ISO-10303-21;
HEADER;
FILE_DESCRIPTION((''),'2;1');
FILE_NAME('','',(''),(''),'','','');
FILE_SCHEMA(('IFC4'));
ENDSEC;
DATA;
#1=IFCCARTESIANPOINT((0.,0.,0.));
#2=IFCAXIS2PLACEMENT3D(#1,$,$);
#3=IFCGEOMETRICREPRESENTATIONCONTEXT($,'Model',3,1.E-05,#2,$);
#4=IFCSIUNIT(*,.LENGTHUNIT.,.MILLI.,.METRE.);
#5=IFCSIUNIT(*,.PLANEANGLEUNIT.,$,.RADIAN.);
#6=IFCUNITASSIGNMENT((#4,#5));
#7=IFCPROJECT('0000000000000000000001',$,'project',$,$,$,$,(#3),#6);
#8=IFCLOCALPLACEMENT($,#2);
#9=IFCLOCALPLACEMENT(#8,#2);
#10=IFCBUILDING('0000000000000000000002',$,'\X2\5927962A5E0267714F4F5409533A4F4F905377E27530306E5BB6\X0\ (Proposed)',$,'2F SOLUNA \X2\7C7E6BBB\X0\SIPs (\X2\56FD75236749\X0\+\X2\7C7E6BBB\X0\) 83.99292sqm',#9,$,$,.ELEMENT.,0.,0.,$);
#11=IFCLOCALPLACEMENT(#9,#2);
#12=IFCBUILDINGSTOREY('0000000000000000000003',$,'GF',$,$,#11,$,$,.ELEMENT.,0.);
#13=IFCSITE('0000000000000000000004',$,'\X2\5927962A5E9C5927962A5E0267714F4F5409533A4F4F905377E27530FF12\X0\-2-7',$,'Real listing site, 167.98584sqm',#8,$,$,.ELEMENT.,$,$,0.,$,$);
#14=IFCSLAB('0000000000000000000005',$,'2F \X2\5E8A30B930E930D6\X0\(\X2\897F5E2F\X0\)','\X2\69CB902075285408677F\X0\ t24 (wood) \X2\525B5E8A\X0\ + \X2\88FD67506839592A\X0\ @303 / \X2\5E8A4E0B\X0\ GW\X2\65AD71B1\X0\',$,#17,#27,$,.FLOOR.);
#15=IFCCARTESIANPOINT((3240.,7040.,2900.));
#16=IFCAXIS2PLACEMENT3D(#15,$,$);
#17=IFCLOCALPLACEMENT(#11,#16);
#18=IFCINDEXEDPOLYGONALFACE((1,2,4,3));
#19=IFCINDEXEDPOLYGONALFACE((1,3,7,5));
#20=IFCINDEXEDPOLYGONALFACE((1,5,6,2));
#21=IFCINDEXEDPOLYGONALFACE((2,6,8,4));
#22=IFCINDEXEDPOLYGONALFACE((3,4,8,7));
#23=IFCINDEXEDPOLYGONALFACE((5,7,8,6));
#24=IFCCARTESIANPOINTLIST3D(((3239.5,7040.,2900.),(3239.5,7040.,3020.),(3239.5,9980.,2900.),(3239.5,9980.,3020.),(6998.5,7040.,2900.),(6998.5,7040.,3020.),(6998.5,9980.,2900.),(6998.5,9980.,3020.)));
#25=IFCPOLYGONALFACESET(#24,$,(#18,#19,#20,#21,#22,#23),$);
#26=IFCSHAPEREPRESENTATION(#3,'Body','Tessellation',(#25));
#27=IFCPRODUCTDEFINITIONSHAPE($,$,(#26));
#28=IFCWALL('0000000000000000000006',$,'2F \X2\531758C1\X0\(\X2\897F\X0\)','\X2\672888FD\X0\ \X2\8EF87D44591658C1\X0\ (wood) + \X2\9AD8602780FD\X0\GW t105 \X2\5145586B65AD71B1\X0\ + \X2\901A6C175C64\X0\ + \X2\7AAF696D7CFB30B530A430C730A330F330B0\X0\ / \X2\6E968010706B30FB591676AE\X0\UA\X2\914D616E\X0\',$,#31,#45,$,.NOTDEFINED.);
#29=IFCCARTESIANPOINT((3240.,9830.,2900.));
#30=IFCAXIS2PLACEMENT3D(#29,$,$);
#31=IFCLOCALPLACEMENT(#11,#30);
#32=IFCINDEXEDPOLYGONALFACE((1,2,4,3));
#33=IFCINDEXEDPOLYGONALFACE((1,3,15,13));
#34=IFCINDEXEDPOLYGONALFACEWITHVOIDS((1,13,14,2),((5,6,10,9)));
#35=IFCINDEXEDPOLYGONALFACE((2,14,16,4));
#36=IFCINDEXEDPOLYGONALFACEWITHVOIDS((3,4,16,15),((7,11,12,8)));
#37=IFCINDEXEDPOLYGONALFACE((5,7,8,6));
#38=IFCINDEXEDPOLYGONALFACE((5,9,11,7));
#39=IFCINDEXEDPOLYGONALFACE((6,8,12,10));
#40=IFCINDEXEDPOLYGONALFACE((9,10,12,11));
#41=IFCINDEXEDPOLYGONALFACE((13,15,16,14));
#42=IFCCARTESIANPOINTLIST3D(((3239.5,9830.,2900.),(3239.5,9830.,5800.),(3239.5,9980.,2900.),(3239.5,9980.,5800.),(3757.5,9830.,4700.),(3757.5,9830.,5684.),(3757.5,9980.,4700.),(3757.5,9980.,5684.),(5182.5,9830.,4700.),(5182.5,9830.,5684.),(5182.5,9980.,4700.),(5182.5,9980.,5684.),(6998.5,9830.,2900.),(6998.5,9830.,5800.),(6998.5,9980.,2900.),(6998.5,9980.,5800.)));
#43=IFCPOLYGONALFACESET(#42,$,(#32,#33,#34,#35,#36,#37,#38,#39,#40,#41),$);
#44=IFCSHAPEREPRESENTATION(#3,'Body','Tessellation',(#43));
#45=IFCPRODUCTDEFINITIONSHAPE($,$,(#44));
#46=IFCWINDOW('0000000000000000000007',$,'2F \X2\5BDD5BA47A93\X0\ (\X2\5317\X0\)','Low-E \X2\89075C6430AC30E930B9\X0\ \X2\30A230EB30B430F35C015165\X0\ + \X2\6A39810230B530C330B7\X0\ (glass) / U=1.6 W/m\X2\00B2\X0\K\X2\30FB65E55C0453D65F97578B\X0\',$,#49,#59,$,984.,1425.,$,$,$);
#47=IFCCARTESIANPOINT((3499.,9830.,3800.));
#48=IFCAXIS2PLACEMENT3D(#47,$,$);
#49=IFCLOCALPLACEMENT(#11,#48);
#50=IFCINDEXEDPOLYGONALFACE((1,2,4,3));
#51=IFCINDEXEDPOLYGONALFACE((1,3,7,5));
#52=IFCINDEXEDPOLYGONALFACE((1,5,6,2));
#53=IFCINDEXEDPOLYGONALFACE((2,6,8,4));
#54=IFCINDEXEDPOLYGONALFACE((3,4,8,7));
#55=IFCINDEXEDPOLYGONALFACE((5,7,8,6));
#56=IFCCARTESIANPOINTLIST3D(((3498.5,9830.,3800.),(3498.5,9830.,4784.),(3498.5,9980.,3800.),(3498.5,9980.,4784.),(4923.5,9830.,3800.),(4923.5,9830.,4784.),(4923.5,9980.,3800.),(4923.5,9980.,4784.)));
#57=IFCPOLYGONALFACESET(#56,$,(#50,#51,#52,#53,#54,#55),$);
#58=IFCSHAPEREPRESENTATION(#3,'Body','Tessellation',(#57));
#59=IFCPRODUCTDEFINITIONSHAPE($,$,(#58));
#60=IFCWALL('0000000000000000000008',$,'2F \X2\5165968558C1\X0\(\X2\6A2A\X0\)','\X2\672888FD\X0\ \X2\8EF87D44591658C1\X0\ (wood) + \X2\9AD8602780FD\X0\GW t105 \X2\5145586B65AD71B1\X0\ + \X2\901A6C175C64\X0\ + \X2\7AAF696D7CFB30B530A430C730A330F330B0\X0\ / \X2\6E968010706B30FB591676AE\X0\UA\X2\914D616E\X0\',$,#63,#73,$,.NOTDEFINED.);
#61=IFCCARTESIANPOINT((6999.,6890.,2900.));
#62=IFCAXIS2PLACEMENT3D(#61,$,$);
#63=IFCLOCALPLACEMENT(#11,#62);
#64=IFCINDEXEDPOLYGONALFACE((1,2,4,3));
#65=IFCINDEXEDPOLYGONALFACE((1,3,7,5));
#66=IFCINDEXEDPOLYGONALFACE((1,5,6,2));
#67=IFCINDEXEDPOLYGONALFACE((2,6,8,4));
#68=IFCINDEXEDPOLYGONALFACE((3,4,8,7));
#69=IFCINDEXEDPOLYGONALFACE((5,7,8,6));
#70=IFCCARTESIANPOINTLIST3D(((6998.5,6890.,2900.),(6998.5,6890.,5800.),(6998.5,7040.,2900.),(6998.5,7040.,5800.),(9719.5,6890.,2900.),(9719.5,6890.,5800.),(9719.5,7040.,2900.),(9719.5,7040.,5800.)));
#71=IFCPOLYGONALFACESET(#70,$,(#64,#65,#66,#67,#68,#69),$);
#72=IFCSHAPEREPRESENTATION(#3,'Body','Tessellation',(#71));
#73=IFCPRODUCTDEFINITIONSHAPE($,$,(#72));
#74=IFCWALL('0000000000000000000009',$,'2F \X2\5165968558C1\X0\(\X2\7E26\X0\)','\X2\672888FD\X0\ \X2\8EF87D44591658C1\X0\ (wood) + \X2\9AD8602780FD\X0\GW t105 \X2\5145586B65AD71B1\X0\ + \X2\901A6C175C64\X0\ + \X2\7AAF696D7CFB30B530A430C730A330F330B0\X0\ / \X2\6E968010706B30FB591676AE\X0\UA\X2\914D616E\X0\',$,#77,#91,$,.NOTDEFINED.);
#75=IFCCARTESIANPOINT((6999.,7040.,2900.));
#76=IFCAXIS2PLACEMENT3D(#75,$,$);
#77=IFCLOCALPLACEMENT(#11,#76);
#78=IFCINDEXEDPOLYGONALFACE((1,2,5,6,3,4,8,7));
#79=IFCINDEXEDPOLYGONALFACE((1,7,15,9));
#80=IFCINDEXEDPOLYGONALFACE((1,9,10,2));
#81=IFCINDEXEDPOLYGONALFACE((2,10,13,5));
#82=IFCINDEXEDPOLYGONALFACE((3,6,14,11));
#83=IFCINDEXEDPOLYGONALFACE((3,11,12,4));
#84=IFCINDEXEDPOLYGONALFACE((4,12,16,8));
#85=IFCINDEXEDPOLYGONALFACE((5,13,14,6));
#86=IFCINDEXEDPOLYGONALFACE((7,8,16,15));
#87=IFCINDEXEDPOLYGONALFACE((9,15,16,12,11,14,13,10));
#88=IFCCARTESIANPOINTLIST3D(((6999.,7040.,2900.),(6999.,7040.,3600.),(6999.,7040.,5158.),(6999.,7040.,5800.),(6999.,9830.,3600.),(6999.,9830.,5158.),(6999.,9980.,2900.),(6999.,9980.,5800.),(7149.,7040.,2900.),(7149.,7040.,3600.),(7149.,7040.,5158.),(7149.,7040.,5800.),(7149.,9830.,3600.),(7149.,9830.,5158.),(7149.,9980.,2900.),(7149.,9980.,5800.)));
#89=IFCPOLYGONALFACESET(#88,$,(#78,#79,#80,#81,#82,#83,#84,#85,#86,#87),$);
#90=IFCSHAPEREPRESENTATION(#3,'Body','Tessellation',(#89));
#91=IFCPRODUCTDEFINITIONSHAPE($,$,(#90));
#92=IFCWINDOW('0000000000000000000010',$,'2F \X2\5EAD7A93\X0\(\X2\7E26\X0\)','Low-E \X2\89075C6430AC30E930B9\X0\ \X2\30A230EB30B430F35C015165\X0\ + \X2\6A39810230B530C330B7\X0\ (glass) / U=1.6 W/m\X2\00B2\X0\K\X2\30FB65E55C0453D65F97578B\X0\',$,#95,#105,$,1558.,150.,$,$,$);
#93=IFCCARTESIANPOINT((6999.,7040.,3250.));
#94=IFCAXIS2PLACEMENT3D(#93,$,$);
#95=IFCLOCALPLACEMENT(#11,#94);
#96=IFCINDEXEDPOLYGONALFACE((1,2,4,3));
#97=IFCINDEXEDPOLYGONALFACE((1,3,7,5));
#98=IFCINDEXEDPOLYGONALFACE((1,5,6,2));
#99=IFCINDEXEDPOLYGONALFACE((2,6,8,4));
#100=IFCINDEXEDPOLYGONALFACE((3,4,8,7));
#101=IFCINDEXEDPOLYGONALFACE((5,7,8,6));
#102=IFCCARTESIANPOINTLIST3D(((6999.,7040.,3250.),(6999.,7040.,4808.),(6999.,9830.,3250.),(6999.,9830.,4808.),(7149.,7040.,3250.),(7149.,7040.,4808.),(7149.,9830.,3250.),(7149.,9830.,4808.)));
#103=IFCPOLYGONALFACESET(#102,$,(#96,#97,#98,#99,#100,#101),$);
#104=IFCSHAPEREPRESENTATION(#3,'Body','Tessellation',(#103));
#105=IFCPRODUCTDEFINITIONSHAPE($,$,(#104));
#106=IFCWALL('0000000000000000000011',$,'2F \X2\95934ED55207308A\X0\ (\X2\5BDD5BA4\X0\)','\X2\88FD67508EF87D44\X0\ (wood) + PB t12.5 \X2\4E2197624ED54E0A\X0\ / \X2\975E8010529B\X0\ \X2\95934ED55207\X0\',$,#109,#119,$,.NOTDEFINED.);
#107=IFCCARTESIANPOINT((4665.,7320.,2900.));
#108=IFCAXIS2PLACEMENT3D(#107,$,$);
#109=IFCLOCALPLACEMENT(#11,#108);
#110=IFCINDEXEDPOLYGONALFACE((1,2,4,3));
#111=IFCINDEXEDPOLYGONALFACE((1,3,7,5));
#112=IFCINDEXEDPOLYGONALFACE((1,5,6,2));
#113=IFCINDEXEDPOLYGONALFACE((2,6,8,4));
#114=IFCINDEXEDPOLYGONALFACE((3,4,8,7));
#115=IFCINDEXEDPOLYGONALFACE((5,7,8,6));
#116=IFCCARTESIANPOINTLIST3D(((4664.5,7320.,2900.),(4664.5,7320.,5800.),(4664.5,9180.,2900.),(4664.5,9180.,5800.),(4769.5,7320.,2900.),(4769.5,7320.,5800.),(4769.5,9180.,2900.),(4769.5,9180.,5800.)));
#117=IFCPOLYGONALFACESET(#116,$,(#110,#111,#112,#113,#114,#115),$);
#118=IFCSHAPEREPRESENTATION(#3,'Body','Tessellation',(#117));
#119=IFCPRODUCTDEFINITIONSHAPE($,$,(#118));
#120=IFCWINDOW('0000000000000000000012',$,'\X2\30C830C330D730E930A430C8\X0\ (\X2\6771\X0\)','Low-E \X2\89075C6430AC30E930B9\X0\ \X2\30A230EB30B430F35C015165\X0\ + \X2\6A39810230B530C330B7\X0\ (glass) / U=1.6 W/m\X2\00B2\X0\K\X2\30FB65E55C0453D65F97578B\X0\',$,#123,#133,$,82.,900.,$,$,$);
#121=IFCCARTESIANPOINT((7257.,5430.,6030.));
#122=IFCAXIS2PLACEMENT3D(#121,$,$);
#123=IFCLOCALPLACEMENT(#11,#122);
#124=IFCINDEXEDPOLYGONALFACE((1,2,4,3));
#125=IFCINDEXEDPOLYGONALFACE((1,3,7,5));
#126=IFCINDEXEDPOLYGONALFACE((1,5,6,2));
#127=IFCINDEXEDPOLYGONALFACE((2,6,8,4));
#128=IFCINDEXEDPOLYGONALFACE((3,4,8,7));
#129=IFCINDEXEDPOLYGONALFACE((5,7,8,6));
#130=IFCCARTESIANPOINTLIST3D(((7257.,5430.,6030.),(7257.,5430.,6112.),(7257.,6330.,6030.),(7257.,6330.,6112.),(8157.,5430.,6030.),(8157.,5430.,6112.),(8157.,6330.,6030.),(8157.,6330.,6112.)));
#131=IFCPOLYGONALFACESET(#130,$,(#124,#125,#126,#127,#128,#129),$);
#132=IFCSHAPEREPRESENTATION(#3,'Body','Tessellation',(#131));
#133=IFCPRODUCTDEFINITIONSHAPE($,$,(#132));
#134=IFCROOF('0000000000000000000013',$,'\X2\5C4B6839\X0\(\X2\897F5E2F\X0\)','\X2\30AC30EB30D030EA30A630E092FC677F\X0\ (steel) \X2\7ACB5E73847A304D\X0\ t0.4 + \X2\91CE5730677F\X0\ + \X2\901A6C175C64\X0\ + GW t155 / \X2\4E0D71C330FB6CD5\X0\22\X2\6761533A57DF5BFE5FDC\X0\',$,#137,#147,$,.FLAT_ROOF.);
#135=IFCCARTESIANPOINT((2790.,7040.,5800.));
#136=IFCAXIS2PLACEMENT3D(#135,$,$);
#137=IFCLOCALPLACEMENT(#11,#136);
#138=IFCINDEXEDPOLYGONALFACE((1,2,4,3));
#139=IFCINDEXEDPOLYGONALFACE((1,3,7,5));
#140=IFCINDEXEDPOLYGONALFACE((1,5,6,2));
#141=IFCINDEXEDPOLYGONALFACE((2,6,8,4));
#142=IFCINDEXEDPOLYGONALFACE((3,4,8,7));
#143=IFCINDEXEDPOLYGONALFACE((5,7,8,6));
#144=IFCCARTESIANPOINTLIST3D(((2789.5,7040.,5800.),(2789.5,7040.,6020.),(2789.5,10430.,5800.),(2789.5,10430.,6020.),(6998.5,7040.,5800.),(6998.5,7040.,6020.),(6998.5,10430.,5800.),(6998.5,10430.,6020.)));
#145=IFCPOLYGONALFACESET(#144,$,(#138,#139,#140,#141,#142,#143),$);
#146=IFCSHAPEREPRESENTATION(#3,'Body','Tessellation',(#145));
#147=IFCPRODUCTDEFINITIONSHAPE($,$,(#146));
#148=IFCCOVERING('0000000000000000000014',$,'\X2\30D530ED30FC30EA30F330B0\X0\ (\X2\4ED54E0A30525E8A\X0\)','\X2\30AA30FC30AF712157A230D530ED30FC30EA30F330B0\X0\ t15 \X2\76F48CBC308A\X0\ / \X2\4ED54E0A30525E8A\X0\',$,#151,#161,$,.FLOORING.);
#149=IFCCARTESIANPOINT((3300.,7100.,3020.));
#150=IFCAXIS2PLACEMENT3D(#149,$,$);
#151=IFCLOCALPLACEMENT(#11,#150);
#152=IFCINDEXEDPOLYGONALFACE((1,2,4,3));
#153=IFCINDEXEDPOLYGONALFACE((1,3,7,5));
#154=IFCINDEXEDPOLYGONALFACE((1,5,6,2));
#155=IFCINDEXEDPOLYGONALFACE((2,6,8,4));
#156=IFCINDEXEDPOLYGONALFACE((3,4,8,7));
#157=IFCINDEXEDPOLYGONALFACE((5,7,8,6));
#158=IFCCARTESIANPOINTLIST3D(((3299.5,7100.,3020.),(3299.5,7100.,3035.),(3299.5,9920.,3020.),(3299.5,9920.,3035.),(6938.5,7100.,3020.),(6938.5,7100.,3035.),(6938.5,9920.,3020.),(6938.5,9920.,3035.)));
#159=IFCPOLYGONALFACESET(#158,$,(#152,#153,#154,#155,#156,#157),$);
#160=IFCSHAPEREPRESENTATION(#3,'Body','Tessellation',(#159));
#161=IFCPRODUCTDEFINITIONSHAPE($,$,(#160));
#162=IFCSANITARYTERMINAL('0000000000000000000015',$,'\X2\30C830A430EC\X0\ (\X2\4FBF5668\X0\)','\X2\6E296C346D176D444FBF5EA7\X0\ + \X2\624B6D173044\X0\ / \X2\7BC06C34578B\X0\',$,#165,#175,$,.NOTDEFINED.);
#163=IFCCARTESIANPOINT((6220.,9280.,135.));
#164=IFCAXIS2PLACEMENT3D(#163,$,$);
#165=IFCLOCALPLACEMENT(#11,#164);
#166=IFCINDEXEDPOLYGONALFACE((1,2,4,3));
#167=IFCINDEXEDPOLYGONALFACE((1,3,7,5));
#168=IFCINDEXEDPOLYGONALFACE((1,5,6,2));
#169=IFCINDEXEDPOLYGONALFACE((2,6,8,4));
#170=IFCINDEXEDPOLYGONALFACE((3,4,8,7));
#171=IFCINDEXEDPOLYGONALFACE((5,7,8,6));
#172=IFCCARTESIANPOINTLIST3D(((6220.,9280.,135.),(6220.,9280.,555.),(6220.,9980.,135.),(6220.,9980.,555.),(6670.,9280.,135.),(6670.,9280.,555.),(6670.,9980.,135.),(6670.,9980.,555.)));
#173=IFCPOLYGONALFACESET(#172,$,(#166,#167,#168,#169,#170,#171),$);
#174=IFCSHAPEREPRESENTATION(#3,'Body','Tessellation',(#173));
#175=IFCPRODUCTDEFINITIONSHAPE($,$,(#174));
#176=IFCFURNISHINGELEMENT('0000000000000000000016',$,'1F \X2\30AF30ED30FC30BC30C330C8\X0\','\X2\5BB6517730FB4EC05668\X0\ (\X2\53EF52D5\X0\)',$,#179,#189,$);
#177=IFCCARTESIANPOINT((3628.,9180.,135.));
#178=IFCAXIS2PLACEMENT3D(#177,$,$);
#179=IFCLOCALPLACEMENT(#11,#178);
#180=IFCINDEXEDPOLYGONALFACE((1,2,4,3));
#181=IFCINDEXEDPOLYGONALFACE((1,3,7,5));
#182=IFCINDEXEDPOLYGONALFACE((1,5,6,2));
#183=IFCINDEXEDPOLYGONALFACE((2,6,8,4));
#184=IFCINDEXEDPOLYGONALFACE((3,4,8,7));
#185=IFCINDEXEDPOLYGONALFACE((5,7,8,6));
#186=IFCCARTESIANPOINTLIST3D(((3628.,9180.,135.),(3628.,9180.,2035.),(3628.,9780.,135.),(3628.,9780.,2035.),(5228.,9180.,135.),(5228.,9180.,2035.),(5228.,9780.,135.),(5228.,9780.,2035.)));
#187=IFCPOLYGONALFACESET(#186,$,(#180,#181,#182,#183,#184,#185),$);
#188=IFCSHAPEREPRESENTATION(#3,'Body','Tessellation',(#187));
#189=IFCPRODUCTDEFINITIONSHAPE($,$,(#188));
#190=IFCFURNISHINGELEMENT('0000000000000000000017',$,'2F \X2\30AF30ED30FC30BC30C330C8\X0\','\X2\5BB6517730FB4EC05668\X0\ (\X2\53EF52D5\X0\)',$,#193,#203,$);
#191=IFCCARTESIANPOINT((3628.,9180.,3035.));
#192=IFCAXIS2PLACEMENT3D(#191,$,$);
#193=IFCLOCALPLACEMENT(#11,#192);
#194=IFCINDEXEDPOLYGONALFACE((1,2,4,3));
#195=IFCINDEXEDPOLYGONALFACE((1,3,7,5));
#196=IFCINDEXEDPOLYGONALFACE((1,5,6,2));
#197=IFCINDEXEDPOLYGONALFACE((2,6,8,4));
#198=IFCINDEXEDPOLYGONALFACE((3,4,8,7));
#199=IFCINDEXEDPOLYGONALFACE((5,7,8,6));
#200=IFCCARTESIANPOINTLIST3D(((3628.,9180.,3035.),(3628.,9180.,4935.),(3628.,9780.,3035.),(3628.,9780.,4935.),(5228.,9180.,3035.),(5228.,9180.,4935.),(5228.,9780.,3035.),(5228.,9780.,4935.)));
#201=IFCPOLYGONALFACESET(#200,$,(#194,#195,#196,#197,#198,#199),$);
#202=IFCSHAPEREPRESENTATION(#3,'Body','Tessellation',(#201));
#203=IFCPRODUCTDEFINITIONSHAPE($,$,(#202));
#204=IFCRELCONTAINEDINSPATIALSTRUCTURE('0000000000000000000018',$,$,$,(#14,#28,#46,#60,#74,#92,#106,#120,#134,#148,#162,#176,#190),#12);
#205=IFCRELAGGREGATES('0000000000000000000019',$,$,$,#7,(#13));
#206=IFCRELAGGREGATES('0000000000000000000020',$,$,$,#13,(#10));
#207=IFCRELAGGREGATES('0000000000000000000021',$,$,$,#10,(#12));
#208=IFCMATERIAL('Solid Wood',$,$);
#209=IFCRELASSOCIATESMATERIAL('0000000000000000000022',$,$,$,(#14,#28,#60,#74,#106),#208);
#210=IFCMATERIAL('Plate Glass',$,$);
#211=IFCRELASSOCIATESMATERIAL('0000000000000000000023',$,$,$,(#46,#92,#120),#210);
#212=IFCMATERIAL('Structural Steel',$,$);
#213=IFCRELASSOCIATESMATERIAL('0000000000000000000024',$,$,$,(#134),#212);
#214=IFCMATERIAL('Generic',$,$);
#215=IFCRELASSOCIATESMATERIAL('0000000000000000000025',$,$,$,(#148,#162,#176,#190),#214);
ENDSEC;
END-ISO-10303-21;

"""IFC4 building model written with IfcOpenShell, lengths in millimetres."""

from ifc_helpers import new_model, si_unit, frame, frame_2d, origin, place, context, project, spatial, rectangle, extrude, material, element, fill, save


model = new_model("IFC4")

# Units and contexts
model_context = context("Model", 3, precision=1e-05, world=origin())
ifc_project = project(units=[si_unit("LENGTHUNIT", "METRE", prefix="MILLI"), si_unit("PLANEANGLEUNIT", "RADIAN")], contexts=[model_context])

# Site, building, storey
site_placement = place(None, origin())
site = spatial("IfcSite", under=ifc_project, at=site_placement, Name="大阪府大阪市東住吉区住道矢田２-2-7", ObjectType="Real listing site, 167.98584sqm", CompositionType="ELEMENT", RefElevation=0.0)
building_placement = place(site_placement, origin())
building = spatial("IfcBuilding", under=site, at=building_placement, Name="大阪市東住吉区住道矢田の家 (Proposed)", ObjectType="2F SOLUNA 籾殻SIPs (国産杉+籾殻) 83.99292sqm", CompositionType="ELEMENT", ElevationOfRefHeight=0.0, ElevationOfTerrain=0.0)
storey_placement = place(building_placement, origin())
storey = spatial("IfcBuildingStorey", under=building, at=storey_placement, Name="GF", CompositionType="ELEMENT", Elevation=0.0)

# Slab
ifc_material_1 = material(Name="Solid Wood")
slab_placement = place(storey_placement, frame((3240.0, 7040.0, 2900.0)))
element("IfcSlab", 1, at=slab_placement, inside=storey, material=ifc_material_1, Name="2F 床スラブ(西帯)", Description="構造用合板 t24 (wood) 剛床 + 製材根太 @303 / 床下 GW断熱", PredefinedType="FLOOR", context=model_context, shape_type="SweptSolid", body=[
    extrude(rectangle(XDim=3759.0, YDim=2940.0, at=frame_2d((1879.0, 1470.0))), frame((3240.0, 7040.0, 2900.0)), (0.0, 0.0, 1.0), 120.0),
])

# Wall, opening, window
wall_1_placement = place(storey_placement, frame((3240.0, 9830.0, 2900.0)))
wall_1 = element("IfcWall", 2, at=wall_1_placement, inside=storey, material=ifc_material_1, Name="2F 北壁(西)", Description="木製 軸組外壁 (wood) + 高性能GW t105 充填断熱 + 通気層 + 窯業系サイディング / 準耐火・外皮UA配慮", PredefinedType="NOTDEFINED", context=model_context, shape_type="SweptSolid", body=[
    extrude(rectangle(XDim=3759.0, YDim=150.0, at=frame_2d((1879.0, 75.0))), frame((3240.0, 9830.0, 2900.0)), (0.0, 0.0, 1.0), 2900.0),
])
opening_1_placement = place(storey_placement, frame((3499.0, 9830.0, 3800.0)))
opening_1 = element("IfcOpeningElement", 3, at=opening_1_placement, cuts=wall_1, PredefinedType="NOTDEFINED", context=model_context, shape_type="SweptSolid", body=[
    extrude(rectangle(XDim=1425.0, YDim=150.0, at=frame_2d((712.0, 75.0))), frame((3499.0, 9830.0, 3800.0)), (0.0, 0.0, 1.0), 984.0),
])
ifc_material_2 = material(Name="Plate Glass")
window_1_placement = place(storey_placement, frame((3499.0, 9830.0, 3800.0)))
window_1 = element("IfcWindow", 4, at=window_1_placement, inside=storey, material=ifc_material_2, Name="2F 寝室窓 (北)", Description="Low-E 複層ガラス アルゴン封入 + 樹脂サッシ (glass) / U=1.6 W/m²K・日射取得型", OverallHeight=984.0, OverallWidth=1425.0, context=model_context, shape_type="SweptSolid", body=[
    extrude(rectangle(XDim=1425.0, YDim=150.0, at=frame_2d((712.0, 75.0))), frame((3499.0, 9830.0, 3800.0)), (0.0, 0.0, 1.0), 984.0),
])
fill(opening_1, window_1)

# Wall
wall_2_placement = place(storey_placement, frame((6999.0, 6890.0, 2900.0)))
element("IfcWall", 5, at=wall_2_placement, inside=storey, material=ifc_material_1, Name="2F 入隅壁(横)", Description="木製 軸組外壁 (wood) + 高性能GW t105 充填断熱 + 通気層 + 窯業系サイディング / 準耐火・外皮UA配慮", PredefinedType="NOTDEFINED", context=model_context, shape_type="SweptSolid", body=[
    extrude(rectangle(XDim=2721.0, YDim=150.0, at=frame_2d((1360.0, 75.0))), frame((6999.0, 6890.0, 2900.0)), (0.0, 0.0, 1.0), 2900.0),
])

# Wall, opening, window
wall_3_placement = place(storey_placement, frame((6999.0, 7040.0, 2900.0)))
wall_3 = element("IfcWall", 6, at=wall_3_placement, inside=storey, material=ifc_material_1, Name="2F 入隅壁(縦)", Description="木製 軸組外壁 (wood) + 高性能GW t105 充填断熱 + 通気層 + 窯業系サイディング / 準耐火・外皮UA配慮", PredefinedType="NOTDEFINED", context=model_context, shape_type="SweptSolid", body=[
    extrude(rectangle(XDim=150.0, YDim=2940.0, at=frame_2d((75.0, 1470.0))), frame((6999.0, 7040.0, 2900.0)), (0.0, 0.0, 1.0), 2900.0),
])
opening_2_placement = place(storey_placement, frame((6999.0, 7040.0, 3250.0)))
opening_2 = element("IfcOpeningElement", 7, at=opening_2_placement, cuts=wall_3, PredefinedType="NOTDEFINED", context=model_context, shape_type="SweptSolid", body=[
    extrude(rectangle(XDim=150.0, YDim=2790.0, at=frame_2d((75.0, 1395.0))), frame((6999.0, 7040.0, 3250.0)), (0.0, 0.0, 1.0), 1558.0),
])
window_2_placement = place(storey_placement, frame((6999.0, 7040.0, 3250.0)))
window_2 = element("IfcWindow", 8, at=window_2_placement, inside=storey, material=ifc_material_2, Name="2F 庭窓(縦)", Description="Low-E 複層ガラス アルゴン封入 + 樹脂サッシ (glass) / U=1.6 W/m²K・日射取得型", OverallHeight=1558.0, OverallWidth=150.0, context=model_context, shape_type="SweptSolid", body=[
    extrude(rectangle(XDim=150.0, YDim=2790.0, at=frame_2d((75.0, 1395.0))), frame((6999.0, 7040.0, 3250.0)), (0.0, 0.0, 1.0), 1558.0),
])
fill(opening_2, window_2)

# Wall
wall_4_placement = place(storey_placement, frame((4665.0, 7320.0, 2900.0)))
element("IfcWall", 9, at=wall_4_placement, inside=storey, material=ifc_material_1, Name="2F 間仕切り (寝室)", Description="製材軸組 (wood) + PB t12.5 両面仕上 / 非耐力 間仕切", PredefinedType="NOTDEFINED", context=model_context, shape_type="SweptSolid", body=[
    extrude(rectangle(XDim=105.0, YDim=1860.0, at=frame_2d((52.0, 930.0))), frame((4665.0, 7320.0, 2900.0)), (0.0, 0.0, 1.0), 2900.0),
])

# Window
window_3_placement = place(storey_placement, frame((7257.0, 5430.0, 6030.0)))
element("IfcWindow", 10, at=window_3_placement, inside=storey, material=ifc_material_2, Name="トップライト (東)", Description="Low-E 複層ガラス アルゴン封入 + 樹脂サッシ (glass) / U=1.6 W/m²K・日射取得型", OverallHeight=82.0, OverallWidth=900.0, context=model_context, shape_type="SweptSolid", body=[
    extrude(rectangle(XDim=900.0, YDim=900.0, at=frame_2d((450.0, 450.0))), frame((7257.0, 5430.0, 6030.0)), (0.0, 0.0, 1.0), 82.0),
])

# Roof
ifc_material_3 = material(Name="Structural Steel")
for number, where, name in (
    (11, (2790.0, 7040.0, 5800.0), "屋根(西帯)"),
):
    element("IfcRoof", number, at=place(storey_placement, frame(where)), inside=storey, material=ifc_material_3, Name=name, Description="ガルバリウム鋼板 (steel) 立平葺き t0.4 + 野地板 + 通気層 + GW t155 / 不燃・法22条区域対応", PredefinedType="FLAT_ROOF", context=model_context, shape_type="SweptSolid", body=[
        extrude(rectangle(XDim=4209.0, YDim=3390.0, at=frame_2d((2104.0, 1695.0))), frame((2790.0, 7040.0, 5800.0)), (0.0, 0.0, 1.0), 220.0),
    ])

# Covering
ifc_material_4 = material(Name="Generic")
covering_placement = place(storey_placement, frame((3300.0, 7100.0, 3020.0)))
element("IfcCovering", 12, at=covering_placement, inside=storey, material=ifc_material_4, Name="フローリング (仕上げ床)", Description="オーク無垢フローリング t15 直貼り / 仕上げ床", PredefinedType="FLOORING", context=model_context, shape_type="SweptSolid", body=[
    extrude(rectangle(XDim=3639.0, YDim=2820.0, at=frame_2d((1819.0, 1410.0))), frame((3300.0, 7100.0, 3020.0)), (0.0, 0.0, 1.0), 15.0),
])

# Sanitary terminal
sanitary_terminal_placement = place(storey_placement, frame((6220.0, 9280.0, 135.0)))
element("IfcSanitaryTerminal", 13, at=sanitary_terminal_placement, inside=storey, material=ifc_material_4, Name="トイレ (便器)", Description="温水洗浄便座 + 手洗い / 節水型", PredefinedType="NOTDEFINED", context=model_context, shape_type="SweptSolid", body=[
    extrude(rectangle(XDim=450.0, YDim=700.0, at=frame_2d((225.0, 350.0))), frame((6220.0, 9280.0, 135.0)), (0.0, 0.0, 1.0), 420.0),
])

# Furnishing elements
furnishing_1_placement = place(storey_placement, frame((3628.0, 9180.0, 135.0)))
element("IfcFurnishingElement", 14, at=furnishing_1_placement, inside=storey, material=ifc_material_4, Name="1F クローゼット", Description="家具・什器 (可動)", context=model_context, shape_type="SweptSolid", body=[
    extrude(rectangle(XDim=1600.0, YDim=600.0, at=frame_2d((800.0, 300.0))), frame((3628.0, 9180.0, 135.0)), (0.0, 0.0, 1.0), 1900.0),
])
furnishing_2_placement = place(storey_placement, frame((3628.0, 9180.0, 3035.0)))
element("IfcFurnishingElement", 15, at=furnishing_2_placement, inside=storey, material=ifc_material_4, Name="2F クローゼット", Description="家具・什器 (可動)", context=model_context, shape_type="SweptSolid", body=[
    extrude(rectangle(XDim=1600.0, YDim=600.0, at=frame_2d((800.0, 300.0))), frame((3628.0, 9180.0, 3035.0)), (0.0, 0.0, 1.0), 1900.0),
])

save(model, "model.ifc")
